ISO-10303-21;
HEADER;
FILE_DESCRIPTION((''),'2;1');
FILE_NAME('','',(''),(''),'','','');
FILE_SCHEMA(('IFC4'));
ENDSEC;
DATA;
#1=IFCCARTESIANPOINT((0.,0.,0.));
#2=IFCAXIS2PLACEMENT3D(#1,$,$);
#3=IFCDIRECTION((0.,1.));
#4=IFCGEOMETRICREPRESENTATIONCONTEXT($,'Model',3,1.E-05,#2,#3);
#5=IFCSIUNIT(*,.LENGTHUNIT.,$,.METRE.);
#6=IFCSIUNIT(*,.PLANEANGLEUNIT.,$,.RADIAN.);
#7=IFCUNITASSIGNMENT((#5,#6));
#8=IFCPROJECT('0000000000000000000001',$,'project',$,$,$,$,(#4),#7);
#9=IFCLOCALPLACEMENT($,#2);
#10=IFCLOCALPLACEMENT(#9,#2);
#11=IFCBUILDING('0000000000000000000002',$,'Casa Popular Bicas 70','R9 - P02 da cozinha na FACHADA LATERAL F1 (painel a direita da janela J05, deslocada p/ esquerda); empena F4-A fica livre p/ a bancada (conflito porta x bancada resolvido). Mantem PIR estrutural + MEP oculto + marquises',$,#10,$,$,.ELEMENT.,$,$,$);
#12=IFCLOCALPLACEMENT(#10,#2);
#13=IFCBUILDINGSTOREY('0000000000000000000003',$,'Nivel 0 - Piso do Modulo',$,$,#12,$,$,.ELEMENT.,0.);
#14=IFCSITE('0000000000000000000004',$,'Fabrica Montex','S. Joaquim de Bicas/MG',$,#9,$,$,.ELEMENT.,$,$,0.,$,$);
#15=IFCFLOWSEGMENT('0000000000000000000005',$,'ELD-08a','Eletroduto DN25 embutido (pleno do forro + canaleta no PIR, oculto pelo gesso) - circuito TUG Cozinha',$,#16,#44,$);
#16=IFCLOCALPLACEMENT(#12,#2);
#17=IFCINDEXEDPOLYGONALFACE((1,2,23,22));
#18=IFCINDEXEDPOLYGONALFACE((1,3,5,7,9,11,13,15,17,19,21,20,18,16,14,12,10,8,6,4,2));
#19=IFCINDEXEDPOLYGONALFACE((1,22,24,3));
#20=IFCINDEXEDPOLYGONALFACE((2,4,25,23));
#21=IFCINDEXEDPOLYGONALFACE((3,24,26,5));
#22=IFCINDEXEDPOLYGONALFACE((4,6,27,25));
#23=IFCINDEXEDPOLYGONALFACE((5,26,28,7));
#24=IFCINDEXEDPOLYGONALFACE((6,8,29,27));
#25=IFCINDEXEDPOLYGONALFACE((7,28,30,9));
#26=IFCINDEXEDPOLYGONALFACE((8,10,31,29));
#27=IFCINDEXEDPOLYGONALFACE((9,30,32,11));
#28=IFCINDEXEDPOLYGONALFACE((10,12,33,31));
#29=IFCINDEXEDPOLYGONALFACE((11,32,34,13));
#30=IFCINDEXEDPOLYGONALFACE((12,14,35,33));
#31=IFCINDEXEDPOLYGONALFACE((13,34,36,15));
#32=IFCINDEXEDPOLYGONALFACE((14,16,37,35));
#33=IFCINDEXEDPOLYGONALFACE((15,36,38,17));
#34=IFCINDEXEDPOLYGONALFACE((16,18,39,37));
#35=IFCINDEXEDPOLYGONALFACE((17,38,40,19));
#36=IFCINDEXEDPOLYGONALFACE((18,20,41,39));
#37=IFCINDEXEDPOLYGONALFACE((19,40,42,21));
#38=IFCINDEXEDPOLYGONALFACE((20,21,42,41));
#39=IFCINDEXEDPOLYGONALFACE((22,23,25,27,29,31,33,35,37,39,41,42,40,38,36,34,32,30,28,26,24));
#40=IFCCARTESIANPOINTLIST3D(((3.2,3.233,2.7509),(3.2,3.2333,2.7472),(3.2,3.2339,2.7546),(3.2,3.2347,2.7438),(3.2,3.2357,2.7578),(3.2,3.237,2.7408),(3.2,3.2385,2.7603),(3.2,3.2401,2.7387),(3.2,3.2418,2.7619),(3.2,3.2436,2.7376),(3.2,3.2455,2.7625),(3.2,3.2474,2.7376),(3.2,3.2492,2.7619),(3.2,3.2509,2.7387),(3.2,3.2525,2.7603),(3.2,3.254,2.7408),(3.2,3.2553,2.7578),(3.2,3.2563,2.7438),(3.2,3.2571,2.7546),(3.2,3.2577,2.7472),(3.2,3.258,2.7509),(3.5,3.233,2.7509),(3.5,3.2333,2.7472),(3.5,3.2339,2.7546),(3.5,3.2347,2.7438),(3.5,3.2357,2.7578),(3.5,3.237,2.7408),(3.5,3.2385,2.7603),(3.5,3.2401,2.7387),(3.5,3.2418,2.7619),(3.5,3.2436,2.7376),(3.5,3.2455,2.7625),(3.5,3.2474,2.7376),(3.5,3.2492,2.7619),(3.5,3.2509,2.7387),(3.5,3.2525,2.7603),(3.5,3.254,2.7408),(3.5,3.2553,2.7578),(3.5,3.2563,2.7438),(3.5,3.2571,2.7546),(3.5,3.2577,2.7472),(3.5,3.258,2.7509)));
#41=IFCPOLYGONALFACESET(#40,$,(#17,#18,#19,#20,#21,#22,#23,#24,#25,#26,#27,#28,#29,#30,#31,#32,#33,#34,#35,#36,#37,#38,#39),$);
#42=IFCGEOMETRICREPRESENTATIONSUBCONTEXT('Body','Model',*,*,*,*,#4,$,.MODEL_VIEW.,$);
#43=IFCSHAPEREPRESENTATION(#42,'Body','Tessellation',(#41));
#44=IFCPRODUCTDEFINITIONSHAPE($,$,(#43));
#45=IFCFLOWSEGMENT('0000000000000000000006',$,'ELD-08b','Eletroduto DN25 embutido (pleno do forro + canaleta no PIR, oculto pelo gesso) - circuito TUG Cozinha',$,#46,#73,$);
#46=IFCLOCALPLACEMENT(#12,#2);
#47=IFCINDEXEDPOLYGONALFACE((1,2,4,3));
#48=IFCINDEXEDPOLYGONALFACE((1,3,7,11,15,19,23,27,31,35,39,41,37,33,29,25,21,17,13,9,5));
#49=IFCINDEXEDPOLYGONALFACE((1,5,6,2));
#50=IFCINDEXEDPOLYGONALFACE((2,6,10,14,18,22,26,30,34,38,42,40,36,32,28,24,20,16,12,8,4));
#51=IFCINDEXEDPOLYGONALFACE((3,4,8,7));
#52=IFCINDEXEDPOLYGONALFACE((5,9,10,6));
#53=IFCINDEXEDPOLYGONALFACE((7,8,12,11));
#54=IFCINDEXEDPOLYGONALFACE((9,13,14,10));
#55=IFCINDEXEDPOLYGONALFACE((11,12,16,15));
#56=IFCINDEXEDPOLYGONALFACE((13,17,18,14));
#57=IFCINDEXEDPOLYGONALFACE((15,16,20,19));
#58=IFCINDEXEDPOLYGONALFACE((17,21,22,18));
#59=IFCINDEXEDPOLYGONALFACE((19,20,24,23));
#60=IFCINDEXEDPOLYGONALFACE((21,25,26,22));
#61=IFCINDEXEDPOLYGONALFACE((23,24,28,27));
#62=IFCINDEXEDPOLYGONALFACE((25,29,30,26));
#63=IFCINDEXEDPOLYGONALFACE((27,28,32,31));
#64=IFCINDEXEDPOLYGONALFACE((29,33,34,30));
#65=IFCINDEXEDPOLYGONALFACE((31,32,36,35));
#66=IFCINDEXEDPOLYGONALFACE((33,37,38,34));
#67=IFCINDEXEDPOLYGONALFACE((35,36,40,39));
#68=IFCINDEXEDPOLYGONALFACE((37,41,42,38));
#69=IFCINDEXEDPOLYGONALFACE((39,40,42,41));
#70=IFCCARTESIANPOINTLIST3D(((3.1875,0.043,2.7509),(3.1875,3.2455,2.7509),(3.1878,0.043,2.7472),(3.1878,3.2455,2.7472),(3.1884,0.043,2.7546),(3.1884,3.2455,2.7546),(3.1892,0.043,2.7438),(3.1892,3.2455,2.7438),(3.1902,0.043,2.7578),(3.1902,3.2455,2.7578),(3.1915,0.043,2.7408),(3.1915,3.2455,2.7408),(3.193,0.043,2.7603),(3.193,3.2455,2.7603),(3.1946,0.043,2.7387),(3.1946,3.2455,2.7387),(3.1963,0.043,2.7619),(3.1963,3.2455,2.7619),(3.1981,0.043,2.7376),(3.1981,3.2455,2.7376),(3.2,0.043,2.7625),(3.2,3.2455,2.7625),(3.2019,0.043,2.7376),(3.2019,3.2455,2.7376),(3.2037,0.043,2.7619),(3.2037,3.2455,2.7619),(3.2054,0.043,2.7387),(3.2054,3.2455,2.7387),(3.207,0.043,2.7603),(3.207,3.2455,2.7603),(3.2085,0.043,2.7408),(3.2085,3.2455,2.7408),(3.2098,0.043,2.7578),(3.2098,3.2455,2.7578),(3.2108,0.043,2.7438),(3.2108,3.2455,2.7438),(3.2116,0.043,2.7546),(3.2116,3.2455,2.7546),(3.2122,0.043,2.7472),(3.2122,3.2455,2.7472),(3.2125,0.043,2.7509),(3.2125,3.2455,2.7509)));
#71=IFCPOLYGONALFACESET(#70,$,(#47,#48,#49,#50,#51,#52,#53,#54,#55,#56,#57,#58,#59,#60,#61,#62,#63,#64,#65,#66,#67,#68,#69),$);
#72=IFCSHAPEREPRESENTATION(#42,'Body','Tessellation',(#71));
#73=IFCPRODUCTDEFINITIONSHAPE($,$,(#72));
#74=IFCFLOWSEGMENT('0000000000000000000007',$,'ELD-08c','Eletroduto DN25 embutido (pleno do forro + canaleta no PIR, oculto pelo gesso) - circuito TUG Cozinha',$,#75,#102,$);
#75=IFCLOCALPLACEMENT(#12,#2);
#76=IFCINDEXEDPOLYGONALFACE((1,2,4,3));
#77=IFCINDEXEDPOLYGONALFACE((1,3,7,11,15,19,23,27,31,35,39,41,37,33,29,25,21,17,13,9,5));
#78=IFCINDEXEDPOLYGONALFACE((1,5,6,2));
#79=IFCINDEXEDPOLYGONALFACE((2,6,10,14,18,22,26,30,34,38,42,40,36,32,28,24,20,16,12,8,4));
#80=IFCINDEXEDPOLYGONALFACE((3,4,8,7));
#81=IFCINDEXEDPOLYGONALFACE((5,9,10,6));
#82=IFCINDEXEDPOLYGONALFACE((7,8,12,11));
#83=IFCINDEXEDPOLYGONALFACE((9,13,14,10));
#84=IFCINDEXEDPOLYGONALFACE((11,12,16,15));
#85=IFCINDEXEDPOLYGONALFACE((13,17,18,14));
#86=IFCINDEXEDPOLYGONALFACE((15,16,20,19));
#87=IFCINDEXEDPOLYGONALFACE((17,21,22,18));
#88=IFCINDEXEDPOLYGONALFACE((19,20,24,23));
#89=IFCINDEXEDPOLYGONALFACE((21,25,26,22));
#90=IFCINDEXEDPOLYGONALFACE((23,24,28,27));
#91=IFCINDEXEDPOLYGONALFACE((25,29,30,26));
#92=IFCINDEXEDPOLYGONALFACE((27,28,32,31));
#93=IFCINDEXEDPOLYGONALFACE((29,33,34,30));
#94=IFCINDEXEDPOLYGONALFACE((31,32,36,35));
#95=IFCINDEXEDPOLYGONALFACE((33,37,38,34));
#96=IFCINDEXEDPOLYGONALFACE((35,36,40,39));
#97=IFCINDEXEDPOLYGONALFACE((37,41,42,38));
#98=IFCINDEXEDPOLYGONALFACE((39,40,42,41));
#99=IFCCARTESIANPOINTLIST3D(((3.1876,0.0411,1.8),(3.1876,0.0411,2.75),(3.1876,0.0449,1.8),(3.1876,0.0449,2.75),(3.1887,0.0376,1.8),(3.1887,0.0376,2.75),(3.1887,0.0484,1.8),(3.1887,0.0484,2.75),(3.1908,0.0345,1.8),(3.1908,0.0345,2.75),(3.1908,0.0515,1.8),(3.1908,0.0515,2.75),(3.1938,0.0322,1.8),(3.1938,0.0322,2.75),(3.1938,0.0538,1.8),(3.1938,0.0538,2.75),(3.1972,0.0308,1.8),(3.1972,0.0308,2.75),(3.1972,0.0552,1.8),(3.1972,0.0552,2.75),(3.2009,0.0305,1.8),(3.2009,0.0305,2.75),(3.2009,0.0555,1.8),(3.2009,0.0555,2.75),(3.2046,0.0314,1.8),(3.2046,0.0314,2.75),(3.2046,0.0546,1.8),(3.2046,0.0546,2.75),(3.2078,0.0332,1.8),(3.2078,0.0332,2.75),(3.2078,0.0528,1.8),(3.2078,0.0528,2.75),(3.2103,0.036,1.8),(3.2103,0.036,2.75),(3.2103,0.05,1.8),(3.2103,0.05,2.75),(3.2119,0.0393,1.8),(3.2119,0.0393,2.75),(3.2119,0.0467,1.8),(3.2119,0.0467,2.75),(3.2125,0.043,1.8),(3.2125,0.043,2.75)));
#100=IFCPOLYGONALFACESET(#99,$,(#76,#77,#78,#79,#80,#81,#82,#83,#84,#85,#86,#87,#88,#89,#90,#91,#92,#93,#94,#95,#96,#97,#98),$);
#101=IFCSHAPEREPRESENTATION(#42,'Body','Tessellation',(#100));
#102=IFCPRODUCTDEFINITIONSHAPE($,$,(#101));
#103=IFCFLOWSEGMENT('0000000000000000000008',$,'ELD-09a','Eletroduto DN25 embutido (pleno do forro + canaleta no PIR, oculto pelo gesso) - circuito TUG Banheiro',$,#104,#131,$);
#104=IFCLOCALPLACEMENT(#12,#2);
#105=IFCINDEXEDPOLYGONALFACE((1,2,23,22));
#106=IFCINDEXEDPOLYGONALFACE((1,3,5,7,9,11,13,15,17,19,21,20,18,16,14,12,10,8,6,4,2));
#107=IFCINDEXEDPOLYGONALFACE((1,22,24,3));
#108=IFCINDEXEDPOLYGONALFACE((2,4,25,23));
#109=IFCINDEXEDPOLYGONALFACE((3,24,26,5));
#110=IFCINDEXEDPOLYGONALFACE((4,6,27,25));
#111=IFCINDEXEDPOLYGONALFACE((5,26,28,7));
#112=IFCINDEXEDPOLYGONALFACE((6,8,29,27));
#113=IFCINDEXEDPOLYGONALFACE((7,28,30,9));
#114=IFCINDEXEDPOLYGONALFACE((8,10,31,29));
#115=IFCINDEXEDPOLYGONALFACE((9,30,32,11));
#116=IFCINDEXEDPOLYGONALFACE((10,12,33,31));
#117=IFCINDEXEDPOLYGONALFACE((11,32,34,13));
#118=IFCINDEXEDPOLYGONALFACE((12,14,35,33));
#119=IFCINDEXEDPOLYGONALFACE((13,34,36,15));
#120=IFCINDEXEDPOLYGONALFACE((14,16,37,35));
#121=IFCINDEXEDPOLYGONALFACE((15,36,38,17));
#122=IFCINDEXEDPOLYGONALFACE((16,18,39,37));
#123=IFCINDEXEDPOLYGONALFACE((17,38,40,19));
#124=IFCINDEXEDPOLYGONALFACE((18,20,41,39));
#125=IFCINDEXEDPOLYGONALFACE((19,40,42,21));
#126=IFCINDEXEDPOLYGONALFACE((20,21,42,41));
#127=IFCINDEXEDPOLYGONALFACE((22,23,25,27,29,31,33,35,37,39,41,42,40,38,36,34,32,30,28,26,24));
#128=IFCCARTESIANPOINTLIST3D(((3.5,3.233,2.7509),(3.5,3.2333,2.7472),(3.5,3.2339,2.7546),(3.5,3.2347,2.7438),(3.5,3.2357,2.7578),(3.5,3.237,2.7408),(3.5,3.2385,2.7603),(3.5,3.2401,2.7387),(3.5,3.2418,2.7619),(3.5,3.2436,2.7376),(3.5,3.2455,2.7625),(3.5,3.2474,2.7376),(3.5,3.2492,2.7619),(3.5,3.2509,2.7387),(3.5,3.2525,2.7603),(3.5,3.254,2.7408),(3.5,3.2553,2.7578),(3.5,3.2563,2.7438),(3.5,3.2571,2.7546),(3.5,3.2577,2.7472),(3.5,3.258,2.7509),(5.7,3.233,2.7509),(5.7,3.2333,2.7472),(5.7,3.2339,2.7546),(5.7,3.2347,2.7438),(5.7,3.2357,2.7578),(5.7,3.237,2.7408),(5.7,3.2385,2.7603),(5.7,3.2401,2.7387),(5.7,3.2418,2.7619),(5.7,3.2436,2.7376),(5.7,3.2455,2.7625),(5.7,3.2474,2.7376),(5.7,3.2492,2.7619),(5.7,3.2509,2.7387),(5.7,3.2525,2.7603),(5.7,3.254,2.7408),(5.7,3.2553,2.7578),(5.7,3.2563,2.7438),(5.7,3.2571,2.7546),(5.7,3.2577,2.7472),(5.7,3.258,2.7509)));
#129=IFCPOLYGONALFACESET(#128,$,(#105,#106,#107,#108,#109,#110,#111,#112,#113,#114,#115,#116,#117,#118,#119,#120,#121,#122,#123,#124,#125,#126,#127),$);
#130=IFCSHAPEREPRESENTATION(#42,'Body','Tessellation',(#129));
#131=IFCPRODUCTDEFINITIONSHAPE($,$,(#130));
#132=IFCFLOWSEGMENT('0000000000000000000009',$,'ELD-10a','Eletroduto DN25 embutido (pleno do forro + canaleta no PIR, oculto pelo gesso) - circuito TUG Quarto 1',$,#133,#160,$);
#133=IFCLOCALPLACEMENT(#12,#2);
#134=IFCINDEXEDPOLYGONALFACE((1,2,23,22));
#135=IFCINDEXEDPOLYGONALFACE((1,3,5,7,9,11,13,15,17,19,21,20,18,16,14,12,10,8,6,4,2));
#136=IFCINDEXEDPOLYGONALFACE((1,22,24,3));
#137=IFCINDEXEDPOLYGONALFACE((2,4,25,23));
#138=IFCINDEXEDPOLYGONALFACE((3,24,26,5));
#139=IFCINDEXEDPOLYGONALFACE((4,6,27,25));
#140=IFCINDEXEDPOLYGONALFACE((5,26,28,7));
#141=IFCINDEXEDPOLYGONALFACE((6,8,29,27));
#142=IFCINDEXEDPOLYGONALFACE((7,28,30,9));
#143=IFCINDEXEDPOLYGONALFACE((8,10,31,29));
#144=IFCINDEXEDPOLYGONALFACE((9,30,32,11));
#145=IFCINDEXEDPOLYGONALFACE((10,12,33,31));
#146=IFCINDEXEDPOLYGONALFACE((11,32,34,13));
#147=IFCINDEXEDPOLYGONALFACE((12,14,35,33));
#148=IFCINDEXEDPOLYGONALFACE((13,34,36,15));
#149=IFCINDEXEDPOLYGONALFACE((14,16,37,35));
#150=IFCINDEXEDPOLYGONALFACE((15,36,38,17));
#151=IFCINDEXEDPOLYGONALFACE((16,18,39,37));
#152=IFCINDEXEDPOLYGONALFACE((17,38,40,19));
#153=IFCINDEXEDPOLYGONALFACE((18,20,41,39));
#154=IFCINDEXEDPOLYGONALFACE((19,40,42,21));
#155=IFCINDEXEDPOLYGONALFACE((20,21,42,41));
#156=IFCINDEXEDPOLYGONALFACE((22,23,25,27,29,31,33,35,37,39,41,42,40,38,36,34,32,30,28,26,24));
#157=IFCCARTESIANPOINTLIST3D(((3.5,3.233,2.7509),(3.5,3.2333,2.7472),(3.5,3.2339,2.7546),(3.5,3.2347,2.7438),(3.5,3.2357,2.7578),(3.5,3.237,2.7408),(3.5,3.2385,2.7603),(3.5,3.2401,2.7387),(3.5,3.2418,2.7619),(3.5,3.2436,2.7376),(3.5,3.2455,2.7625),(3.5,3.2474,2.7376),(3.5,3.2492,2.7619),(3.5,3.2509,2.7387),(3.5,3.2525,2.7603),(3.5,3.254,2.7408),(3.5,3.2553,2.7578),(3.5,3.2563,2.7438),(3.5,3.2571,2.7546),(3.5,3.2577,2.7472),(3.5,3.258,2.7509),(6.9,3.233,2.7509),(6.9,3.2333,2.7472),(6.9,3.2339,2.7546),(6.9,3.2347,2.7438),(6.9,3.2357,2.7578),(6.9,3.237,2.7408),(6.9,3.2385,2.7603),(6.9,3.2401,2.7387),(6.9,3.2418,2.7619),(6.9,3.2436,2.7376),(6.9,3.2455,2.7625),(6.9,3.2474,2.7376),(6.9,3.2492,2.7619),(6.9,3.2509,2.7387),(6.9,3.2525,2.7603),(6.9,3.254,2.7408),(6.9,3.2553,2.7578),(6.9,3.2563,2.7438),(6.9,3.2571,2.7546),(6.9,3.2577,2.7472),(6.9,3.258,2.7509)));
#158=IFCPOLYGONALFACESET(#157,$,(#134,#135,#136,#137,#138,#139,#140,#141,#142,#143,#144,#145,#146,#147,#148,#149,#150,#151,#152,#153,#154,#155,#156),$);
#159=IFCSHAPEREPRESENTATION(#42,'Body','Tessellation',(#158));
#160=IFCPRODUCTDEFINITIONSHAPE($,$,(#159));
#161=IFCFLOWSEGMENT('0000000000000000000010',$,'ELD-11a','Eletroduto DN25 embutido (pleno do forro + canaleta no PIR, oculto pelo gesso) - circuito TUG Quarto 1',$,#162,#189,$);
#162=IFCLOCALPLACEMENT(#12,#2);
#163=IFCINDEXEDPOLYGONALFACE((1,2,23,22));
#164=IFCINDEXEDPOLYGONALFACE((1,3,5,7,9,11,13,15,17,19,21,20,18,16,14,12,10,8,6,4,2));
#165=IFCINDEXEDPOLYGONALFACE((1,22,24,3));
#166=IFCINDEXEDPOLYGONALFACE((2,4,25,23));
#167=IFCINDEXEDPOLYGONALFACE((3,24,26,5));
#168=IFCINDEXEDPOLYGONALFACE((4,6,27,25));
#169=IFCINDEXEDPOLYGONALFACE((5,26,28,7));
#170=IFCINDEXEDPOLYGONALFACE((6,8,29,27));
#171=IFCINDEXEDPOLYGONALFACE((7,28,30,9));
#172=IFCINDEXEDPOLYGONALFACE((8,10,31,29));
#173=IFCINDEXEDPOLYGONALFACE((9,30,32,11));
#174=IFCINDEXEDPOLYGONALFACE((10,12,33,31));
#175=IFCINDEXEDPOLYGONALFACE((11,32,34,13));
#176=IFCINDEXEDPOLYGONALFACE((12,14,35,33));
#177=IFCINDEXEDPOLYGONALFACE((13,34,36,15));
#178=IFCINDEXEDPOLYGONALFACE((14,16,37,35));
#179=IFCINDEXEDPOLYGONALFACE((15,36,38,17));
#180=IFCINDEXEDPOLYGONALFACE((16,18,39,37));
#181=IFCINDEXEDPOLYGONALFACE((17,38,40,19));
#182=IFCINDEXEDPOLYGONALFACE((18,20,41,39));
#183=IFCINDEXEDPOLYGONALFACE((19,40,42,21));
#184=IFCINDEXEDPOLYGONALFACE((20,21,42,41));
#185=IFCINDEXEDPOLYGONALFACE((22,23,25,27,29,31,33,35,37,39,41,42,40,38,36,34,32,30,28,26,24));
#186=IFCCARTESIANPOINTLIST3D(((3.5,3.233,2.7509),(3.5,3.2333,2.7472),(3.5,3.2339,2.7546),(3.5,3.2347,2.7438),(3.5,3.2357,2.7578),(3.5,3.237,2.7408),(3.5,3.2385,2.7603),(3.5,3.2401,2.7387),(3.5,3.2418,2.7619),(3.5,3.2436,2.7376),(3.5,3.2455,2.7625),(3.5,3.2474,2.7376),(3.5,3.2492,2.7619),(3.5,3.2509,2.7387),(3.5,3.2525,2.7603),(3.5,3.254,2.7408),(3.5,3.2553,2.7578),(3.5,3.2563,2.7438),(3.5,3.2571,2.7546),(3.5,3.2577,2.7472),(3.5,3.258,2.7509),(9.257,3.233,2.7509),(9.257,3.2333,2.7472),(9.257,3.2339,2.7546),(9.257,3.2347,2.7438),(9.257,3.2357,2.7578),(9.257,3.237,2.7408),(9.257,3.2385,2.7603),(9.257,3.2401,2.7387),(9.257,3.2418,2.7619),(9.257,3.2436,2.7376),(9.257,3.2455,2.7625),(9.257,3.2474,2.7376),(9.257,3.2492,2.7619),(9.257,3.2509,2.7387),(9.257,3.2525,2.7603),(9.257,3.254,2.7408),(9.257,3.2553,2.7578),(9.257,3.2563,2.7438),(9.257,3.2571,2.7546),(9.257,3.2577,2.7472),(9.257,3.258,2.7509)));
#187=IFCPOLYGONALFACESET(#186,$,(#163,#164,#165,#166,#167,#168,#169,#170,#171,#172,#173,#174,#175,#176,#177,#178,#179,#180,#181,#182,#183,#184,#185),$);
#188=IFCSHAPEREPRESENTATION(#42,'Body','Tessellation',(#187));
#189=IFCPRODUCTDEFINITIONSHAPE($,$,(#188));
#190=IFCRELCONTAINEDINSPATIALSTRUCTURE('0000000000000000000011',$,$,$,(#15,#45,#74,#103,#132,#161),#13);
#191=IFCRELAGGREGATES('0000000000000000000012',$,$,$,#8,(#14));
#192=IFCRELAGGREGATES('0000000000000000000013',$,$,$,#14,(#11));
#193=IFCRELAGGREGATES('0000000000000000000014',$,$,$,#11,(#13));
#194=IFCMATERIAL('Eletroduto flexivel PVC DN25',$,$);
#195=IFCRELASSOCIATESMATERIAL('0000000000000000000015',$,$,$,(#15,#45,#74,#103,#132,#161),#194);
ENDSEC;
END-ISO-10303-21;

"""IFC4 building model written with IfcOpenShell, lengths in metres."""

from ifc_helpers import new_model, si_unit, direction, frame, origin, origin_2d, place, context, subcontext, project, spatial, circle, extrude, material, element, save


model = new_model("IFC4")

# Units and contexts
model_context = context("Model", 3, precision=1e-05, world=origin(), true_north=direction((0.0, 1.0)))
body_context = subcontext(model_context, "Body", "Model", "MODEL_VIEW")
ifc_project = project(units=[si_unit("LENGTHUNIT", "METRE"), si_unit("PLANEANGLEUNIT", "RADIAN")], contexts=[model_context])

# Site, building, storey
site_placement = place(None, origin())
site = spatial("IfcSite", under=ifc_project, at=site_placement, Name="Fabrica Montex", Description="S. Joaquim de Bicas/MG", CompositionType="ELEMENT", RefElevation=0.0)
building_placement = place(site_placement, origin())
building = spatial("IfcBuilding", under=site, at=building_placement, Name="Casa Popular Bicas 70", Description="R9 - P02 da cozinha na FACHADA LATERAL F1 (painel a direita da janela J05, deslocada p/ esquerda); empena F4-A fica livre p/ a bancada (conflito porta x bancada resolvido). Mantem PIR estrutural + MEP oculto + marquises", CompositionType="ELEMENT")
storey_placement = place(building_placement, origin())
storey = spatial("IfcBuildingStorey", under=building, at=storey_placement, Name="Nivel 0 - Piso do Modulo", CompositionType="ELEMENT", Elevation=0.0)

# Flow segments
ifc_material_1 = material(Name="Eletroduto flexivel PVC DN25")
flow_segment_1_placement = place(storey_placement, frame((3.5, 3.2455, 2.75), z_axis=(-1.0, 0.0, 0.0), x_axis=(0.0, 0.0, 1.0)))
element("IfcFlowSegment", 1, at=flow_segment_1_placement, inside=storey, material=ifc_material_1, Name="ELD-08a", Description="Eletroduto DN25 embutido (pleno do forro + canaleta no PIR, oculto pelo gesso) - circuito TUG Cozinha", context=body_context, shape_type="SweptSolid", body=[
    extrude(circle(Radius=0.0125, at=origin_2d()), origin(), (0.0, 0.0, 1.0), 0.3),
])
flow_segment_2_placement = place(storey_placement, frame((3.2, 3.2455, 2.75), z_axis=(0.0, -1.0, 0.0), x_axis=(0.0, 0.0, 1.0)))
element("IfcFlowSegment", 2, at=flow_segment_2_placement, inside=storey, material=ifc_material_1, Name="ELD-08b", Description="Eletroduto DN25 embutido (pleno do forro + canaleta no PIR, oculto pelo gesso) - circuito TUG Cozinha", context=body_context, shape_type="SweptSolid", body=[
    extrude(circle(Radius=0.0125, at=origin_2d()), origin(), (0.0, 0.0, 1.0), 3.2025),
])
flow_segment_3_placement = place(storey_placement, frame((3.2, 0.043, 2.75), z_axis=(0.0, 0.0, -1.0), x_axis=(1.0, 0.0, 0.0)))
element("IfcFlowSegment", 3, at=flow_segment_3_placement, inside=storey, material=ifc_material_1, Name="ELD-08c", Description="Eletroduto DN25 embutido (pleno do forro + canaleta no PIR, oculto pelo gesso) - circuito TUG Cozinha", context=body_context, shape_type="SweptSolid", body=[
    extrude(circle(Radius=0.0125, at=origin_2d()), origin(), (0.0, 0.0, 1.0), 0.95),
])
flow_segment_4_placement = place(storey_placement, frame((3.5, 3.2455, 2.75), z_axis=(1.0, 0.0, 0.0), x_axis=(0.0, 0.0, 1.0)))
element("IfcFlowSegment", 4, at=flow_segment_4_placement, inside=storey, material=ifc_material_1, Name="ELD-09a", Description="Eletroduto DN25 embutido (pleno do forro + canaleta no PIR, oculto pelo gesso) - circuito TUG Banheiro", context=body_context, shape_type="SweptSolid", body=[
    extrude(circle(Radius=0.0125, at=origin_2d()), origin(), (0.0, 0.0, 1.0), 2.2),
])
flow_segment_5_placement = place(storey_placement, frame((3.5, 3.2455, 2.75), z_axis=(1.0, 0.0, 0.0), x_axis=(0.0, 0.0, 1.0)))
element("IfcFlowSegment", 5, at=flow_segment_5_placement, inside=storey, material=ifc_material_1, Name="ELD-10a", Description="Eletroduto DN25 embutido (pleno do forro + canaleta no PIR, oculto pelo gesso) - circuito TUG Quarto 1", context=body_context, shape_type="SweptSolid", body=[
    extrude(circle(Radius=0.0125, at=origin_2d()), origin(), (0.0, 0.0, 1.0), 3.4),
])
flow_segment_6_placement = place(storey_placement, frame((3.5, 3.2455, 2.75), z_axis=(1.0, 0.0, 0.0), x_axis=(0.0, 0.0, 1.0)))
element("IfcFlowSegment", 6, at=flow_segment_6_placement, inside=storey, material=ifc_material_1, Name="ELD-11a", Description="Eletroduto DN25 embutido (pleno do forro + canaleta no PIR, oculto pelo gesso) - circuito TUG Quarto 1", context=body_context, shape_type="SweptSolid", body=[
    extrude(circle(Radius=0.0125, at=origin_2d()), origin(), (0.0, 0.0, 1.0), 5.757),
])

save(model, "model.ifc")
